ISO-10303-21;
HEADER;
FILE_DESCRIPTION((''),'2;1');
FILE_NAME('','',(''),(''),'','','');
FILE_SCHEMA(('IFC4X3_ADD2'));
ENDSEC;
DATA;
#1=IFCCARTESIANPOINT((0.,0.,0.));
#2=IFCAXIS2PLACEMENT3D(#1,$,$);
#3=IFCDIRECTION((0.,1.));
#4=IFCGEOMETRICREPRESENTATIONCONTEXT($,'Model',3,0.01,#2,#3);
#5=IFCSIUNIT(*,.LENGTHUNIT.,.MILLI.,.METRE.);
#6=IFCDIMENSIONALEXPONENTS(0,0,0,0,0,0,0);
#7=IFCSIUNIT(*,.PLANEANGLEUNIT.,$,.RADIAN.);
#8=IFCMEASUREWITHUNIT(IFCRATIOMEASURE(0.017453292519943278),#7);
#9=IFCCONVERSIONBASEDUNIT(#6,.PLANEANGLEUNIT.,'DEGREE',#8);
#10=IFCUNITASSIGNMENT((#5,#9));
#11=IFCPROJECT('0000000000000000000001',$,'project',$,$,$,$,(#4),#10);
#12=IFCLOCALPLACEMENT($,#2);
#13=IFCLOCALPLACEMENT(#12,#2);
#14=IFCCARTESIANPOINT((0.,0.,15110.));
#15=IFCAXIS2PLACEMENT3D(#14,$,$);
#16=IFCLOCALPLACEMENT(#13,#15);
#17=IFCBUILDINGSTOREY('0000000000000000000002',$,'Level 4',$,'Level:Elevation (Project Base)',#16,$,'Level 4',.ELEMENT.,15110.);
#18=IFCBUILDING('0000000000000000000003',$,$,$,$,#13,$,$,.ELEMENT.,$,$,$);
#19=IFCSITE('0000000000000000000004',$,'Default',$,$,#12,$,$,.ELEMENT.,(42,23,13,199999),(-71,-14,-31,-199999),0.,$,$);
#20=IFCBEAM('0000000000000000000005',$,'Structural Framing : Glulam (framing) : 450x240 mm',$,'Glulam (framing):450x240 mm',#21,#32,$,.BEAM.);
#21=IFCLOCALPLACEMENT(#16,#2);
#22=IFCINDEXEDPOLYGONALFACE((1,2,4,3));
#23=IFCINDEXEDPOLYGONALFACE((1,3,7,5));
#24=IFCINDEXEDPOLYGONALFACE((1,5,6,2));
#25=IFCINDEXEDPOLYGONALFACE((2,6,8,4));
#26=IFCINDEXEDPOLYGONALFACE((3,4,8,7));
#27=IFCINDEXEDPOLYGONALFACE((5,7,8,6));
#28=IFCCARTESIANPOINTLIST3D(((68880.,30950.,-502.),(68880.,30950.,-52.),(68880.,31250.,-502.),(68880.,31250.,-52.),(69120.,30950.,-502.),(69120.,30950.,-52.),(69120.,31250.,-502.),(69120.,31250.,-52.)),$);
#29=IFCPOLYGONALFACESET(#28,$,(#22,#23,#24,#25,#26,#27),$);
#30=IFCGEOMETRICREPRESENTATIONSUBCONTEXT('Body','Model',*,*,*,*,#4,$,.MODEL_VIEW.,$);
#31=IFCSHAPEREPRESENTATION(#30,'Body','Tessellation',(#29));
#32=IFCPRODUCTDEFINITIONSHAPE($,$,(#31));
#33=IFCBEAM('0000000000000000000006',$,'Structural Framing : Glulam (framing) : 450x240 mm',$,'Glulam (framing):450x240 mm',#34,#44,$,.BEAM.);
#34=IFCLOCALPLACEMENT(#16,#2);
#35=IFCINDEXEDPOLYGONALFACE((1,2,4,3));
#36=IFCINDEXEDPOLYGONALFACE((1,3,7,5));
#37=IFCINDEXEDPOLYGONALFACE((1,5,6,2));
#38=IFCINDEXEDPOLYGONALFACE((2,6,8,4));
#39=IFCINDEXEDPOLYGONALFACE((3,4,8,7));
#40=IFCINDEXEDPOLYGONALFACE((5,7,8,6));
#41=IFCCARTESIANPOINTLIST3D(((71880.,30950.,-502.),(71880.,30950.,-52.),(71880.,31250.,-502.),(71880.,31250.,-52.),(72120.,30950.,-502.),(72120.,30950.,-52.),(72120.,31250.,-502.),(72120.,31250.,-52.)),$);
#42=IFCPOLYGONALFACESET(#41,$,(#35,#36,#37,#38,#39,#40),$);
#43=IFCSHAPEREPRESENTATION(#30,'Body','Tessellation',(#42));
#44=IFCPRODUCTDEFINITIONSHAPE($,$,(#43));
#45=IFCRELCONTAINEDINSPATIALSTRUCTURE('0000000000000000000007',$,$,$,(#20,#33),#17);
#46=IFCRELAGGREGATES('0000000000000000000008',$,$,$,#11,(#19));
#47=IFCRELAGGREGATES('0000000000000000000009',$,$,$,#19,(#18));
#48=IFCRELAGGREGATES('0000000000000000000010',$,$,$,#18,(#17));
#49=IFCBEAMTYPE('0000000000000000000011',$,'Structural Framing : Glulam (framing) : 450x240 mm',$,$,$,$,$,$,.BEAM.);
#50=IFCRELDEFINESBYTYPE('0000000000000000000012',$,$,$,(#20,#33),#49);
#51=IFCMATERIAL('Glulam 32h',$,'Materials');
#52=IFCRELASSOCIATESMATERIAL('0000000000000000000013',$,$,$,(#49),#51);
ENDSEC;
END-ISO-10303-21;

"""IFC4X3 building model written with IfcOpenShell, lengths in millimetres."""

from ifc_helpers import new_model, entity, si_unit, converted_unit, direction, frame, origin, origin_2d_with_axis, place, context, subcontext, project, spatial, rectangle, extrude, source, transform, mapped, material, material_profile, profile_set, type_object, type_shapes, element, save


model = new_model("IFC4X3")

# Units and contexts
model_context = context("Model", 3, precision=0.01, world=origin(), true_north=direction((0.0, 1.0)))
body_context = subcontext(model_context, "Body", "Model", "MODEL_VIEW")
ifc_project = project(units=[si_unit("LENGTHUNIT", "METRE", prefix="MILLI"), converted_unit("PLANEANGLEUNIT", "DEGREE", entity("IfcRatioMeasure", 0.017453292519943278), si_unit("PLANEANGLEUNIT", "RADIAN"), dimensions=[0, 0, 0, 0, 0, 0, 0])], contexts=[model_context])

# Site, building, storey
site_placement = place(None, origin())
site = spatial("IfcSite", under=ifc_project, at=site_placement, Name="Default", CompositionType="ELEMENT", RefLatitude=(42, 23, 13, 199999), RefLongitude=(-71, -14, -31, -199999), RefElevation=0.0)
building_placement = place(site_placement, origin())
building = spatial("IfcBuilding", under=site, at=building_placement, CompositionType="ELEMENT")
storey_placement = place(building_placement, frame((0.0, 0.0, 15110.0)))
storey = spatial("IfcBuildingStorey", under=building, at=storey_placement, Name="Level 4", ObjectType="Level:Elevation (Project Base)", LongName="Level 4", CompositionType="ELEMENT", Elevation=15110.0)

# Beams
ifc_material_1 = material(Name="Glulam 32h", Category="Materials")
ifc_material_profile_1 = material_profile(ifc_material_1, rectangle(XDim=450.0, YDim=240.0, at=origin_2d_with_axis()), Name="450x240 mm")
ifc_profile_set_1 = profile_set([ifc_material_profile_1], Name="450x240 mm")
beam_type_1 = type_object("IfcBeamType", Name="Structural Framing : Glulam (framing) : 450x240 mm", PredefinedType="BEAM", material=ifc_profile_set_1)
shared_shape_1 = source(origin(), body_context, "Body", "SweptSolid", [
    extrude(rectangle(XDim=450.0, YDim=240.0, at=origin_2d_with_axis()), frame((4293.7, 0.0, 0.0), z_axis=(1.0, 0.0, 0.0), x_axis=(0.0, 0.0, -1.0)), (0.0, 0.0, 1.0), 300.0),
])
type_shapes(beam_type_1, [shared_shape_1])
for number, where, z_axis, x_axis, name in (
    (1, (69000.0, 35543.7, -277.0), (0.0, 0.0, 1.0), (0.0, -1.0, 0.0), "Structural Framing : Glulam (framing) : 450x240 mm"),
    (2, (72000.0, 35543.7, -277.0), (0.0, 0.0, 1.0), (0.0, -1.0, 0.0), "Structural Framing : Glulam (framing) : 450x240 mm"),
):
    element("IfcBeam", number, at=place(storey_placement, frame(where, z_axis=z_axis, x_axis=x_axis)), inside=storey, type_object=beam_type_1, Name=name, ObjectType="Glulam (framing):450x240 mm", PredefinedType="BEAM", context=body_context, shape_type="MappedRepresentation", body=[
        mapped(shared_shape_1, transform((0.0, 0.0, 0.0), scale=1.0)),
    ])

save(model, "model.ifc")
